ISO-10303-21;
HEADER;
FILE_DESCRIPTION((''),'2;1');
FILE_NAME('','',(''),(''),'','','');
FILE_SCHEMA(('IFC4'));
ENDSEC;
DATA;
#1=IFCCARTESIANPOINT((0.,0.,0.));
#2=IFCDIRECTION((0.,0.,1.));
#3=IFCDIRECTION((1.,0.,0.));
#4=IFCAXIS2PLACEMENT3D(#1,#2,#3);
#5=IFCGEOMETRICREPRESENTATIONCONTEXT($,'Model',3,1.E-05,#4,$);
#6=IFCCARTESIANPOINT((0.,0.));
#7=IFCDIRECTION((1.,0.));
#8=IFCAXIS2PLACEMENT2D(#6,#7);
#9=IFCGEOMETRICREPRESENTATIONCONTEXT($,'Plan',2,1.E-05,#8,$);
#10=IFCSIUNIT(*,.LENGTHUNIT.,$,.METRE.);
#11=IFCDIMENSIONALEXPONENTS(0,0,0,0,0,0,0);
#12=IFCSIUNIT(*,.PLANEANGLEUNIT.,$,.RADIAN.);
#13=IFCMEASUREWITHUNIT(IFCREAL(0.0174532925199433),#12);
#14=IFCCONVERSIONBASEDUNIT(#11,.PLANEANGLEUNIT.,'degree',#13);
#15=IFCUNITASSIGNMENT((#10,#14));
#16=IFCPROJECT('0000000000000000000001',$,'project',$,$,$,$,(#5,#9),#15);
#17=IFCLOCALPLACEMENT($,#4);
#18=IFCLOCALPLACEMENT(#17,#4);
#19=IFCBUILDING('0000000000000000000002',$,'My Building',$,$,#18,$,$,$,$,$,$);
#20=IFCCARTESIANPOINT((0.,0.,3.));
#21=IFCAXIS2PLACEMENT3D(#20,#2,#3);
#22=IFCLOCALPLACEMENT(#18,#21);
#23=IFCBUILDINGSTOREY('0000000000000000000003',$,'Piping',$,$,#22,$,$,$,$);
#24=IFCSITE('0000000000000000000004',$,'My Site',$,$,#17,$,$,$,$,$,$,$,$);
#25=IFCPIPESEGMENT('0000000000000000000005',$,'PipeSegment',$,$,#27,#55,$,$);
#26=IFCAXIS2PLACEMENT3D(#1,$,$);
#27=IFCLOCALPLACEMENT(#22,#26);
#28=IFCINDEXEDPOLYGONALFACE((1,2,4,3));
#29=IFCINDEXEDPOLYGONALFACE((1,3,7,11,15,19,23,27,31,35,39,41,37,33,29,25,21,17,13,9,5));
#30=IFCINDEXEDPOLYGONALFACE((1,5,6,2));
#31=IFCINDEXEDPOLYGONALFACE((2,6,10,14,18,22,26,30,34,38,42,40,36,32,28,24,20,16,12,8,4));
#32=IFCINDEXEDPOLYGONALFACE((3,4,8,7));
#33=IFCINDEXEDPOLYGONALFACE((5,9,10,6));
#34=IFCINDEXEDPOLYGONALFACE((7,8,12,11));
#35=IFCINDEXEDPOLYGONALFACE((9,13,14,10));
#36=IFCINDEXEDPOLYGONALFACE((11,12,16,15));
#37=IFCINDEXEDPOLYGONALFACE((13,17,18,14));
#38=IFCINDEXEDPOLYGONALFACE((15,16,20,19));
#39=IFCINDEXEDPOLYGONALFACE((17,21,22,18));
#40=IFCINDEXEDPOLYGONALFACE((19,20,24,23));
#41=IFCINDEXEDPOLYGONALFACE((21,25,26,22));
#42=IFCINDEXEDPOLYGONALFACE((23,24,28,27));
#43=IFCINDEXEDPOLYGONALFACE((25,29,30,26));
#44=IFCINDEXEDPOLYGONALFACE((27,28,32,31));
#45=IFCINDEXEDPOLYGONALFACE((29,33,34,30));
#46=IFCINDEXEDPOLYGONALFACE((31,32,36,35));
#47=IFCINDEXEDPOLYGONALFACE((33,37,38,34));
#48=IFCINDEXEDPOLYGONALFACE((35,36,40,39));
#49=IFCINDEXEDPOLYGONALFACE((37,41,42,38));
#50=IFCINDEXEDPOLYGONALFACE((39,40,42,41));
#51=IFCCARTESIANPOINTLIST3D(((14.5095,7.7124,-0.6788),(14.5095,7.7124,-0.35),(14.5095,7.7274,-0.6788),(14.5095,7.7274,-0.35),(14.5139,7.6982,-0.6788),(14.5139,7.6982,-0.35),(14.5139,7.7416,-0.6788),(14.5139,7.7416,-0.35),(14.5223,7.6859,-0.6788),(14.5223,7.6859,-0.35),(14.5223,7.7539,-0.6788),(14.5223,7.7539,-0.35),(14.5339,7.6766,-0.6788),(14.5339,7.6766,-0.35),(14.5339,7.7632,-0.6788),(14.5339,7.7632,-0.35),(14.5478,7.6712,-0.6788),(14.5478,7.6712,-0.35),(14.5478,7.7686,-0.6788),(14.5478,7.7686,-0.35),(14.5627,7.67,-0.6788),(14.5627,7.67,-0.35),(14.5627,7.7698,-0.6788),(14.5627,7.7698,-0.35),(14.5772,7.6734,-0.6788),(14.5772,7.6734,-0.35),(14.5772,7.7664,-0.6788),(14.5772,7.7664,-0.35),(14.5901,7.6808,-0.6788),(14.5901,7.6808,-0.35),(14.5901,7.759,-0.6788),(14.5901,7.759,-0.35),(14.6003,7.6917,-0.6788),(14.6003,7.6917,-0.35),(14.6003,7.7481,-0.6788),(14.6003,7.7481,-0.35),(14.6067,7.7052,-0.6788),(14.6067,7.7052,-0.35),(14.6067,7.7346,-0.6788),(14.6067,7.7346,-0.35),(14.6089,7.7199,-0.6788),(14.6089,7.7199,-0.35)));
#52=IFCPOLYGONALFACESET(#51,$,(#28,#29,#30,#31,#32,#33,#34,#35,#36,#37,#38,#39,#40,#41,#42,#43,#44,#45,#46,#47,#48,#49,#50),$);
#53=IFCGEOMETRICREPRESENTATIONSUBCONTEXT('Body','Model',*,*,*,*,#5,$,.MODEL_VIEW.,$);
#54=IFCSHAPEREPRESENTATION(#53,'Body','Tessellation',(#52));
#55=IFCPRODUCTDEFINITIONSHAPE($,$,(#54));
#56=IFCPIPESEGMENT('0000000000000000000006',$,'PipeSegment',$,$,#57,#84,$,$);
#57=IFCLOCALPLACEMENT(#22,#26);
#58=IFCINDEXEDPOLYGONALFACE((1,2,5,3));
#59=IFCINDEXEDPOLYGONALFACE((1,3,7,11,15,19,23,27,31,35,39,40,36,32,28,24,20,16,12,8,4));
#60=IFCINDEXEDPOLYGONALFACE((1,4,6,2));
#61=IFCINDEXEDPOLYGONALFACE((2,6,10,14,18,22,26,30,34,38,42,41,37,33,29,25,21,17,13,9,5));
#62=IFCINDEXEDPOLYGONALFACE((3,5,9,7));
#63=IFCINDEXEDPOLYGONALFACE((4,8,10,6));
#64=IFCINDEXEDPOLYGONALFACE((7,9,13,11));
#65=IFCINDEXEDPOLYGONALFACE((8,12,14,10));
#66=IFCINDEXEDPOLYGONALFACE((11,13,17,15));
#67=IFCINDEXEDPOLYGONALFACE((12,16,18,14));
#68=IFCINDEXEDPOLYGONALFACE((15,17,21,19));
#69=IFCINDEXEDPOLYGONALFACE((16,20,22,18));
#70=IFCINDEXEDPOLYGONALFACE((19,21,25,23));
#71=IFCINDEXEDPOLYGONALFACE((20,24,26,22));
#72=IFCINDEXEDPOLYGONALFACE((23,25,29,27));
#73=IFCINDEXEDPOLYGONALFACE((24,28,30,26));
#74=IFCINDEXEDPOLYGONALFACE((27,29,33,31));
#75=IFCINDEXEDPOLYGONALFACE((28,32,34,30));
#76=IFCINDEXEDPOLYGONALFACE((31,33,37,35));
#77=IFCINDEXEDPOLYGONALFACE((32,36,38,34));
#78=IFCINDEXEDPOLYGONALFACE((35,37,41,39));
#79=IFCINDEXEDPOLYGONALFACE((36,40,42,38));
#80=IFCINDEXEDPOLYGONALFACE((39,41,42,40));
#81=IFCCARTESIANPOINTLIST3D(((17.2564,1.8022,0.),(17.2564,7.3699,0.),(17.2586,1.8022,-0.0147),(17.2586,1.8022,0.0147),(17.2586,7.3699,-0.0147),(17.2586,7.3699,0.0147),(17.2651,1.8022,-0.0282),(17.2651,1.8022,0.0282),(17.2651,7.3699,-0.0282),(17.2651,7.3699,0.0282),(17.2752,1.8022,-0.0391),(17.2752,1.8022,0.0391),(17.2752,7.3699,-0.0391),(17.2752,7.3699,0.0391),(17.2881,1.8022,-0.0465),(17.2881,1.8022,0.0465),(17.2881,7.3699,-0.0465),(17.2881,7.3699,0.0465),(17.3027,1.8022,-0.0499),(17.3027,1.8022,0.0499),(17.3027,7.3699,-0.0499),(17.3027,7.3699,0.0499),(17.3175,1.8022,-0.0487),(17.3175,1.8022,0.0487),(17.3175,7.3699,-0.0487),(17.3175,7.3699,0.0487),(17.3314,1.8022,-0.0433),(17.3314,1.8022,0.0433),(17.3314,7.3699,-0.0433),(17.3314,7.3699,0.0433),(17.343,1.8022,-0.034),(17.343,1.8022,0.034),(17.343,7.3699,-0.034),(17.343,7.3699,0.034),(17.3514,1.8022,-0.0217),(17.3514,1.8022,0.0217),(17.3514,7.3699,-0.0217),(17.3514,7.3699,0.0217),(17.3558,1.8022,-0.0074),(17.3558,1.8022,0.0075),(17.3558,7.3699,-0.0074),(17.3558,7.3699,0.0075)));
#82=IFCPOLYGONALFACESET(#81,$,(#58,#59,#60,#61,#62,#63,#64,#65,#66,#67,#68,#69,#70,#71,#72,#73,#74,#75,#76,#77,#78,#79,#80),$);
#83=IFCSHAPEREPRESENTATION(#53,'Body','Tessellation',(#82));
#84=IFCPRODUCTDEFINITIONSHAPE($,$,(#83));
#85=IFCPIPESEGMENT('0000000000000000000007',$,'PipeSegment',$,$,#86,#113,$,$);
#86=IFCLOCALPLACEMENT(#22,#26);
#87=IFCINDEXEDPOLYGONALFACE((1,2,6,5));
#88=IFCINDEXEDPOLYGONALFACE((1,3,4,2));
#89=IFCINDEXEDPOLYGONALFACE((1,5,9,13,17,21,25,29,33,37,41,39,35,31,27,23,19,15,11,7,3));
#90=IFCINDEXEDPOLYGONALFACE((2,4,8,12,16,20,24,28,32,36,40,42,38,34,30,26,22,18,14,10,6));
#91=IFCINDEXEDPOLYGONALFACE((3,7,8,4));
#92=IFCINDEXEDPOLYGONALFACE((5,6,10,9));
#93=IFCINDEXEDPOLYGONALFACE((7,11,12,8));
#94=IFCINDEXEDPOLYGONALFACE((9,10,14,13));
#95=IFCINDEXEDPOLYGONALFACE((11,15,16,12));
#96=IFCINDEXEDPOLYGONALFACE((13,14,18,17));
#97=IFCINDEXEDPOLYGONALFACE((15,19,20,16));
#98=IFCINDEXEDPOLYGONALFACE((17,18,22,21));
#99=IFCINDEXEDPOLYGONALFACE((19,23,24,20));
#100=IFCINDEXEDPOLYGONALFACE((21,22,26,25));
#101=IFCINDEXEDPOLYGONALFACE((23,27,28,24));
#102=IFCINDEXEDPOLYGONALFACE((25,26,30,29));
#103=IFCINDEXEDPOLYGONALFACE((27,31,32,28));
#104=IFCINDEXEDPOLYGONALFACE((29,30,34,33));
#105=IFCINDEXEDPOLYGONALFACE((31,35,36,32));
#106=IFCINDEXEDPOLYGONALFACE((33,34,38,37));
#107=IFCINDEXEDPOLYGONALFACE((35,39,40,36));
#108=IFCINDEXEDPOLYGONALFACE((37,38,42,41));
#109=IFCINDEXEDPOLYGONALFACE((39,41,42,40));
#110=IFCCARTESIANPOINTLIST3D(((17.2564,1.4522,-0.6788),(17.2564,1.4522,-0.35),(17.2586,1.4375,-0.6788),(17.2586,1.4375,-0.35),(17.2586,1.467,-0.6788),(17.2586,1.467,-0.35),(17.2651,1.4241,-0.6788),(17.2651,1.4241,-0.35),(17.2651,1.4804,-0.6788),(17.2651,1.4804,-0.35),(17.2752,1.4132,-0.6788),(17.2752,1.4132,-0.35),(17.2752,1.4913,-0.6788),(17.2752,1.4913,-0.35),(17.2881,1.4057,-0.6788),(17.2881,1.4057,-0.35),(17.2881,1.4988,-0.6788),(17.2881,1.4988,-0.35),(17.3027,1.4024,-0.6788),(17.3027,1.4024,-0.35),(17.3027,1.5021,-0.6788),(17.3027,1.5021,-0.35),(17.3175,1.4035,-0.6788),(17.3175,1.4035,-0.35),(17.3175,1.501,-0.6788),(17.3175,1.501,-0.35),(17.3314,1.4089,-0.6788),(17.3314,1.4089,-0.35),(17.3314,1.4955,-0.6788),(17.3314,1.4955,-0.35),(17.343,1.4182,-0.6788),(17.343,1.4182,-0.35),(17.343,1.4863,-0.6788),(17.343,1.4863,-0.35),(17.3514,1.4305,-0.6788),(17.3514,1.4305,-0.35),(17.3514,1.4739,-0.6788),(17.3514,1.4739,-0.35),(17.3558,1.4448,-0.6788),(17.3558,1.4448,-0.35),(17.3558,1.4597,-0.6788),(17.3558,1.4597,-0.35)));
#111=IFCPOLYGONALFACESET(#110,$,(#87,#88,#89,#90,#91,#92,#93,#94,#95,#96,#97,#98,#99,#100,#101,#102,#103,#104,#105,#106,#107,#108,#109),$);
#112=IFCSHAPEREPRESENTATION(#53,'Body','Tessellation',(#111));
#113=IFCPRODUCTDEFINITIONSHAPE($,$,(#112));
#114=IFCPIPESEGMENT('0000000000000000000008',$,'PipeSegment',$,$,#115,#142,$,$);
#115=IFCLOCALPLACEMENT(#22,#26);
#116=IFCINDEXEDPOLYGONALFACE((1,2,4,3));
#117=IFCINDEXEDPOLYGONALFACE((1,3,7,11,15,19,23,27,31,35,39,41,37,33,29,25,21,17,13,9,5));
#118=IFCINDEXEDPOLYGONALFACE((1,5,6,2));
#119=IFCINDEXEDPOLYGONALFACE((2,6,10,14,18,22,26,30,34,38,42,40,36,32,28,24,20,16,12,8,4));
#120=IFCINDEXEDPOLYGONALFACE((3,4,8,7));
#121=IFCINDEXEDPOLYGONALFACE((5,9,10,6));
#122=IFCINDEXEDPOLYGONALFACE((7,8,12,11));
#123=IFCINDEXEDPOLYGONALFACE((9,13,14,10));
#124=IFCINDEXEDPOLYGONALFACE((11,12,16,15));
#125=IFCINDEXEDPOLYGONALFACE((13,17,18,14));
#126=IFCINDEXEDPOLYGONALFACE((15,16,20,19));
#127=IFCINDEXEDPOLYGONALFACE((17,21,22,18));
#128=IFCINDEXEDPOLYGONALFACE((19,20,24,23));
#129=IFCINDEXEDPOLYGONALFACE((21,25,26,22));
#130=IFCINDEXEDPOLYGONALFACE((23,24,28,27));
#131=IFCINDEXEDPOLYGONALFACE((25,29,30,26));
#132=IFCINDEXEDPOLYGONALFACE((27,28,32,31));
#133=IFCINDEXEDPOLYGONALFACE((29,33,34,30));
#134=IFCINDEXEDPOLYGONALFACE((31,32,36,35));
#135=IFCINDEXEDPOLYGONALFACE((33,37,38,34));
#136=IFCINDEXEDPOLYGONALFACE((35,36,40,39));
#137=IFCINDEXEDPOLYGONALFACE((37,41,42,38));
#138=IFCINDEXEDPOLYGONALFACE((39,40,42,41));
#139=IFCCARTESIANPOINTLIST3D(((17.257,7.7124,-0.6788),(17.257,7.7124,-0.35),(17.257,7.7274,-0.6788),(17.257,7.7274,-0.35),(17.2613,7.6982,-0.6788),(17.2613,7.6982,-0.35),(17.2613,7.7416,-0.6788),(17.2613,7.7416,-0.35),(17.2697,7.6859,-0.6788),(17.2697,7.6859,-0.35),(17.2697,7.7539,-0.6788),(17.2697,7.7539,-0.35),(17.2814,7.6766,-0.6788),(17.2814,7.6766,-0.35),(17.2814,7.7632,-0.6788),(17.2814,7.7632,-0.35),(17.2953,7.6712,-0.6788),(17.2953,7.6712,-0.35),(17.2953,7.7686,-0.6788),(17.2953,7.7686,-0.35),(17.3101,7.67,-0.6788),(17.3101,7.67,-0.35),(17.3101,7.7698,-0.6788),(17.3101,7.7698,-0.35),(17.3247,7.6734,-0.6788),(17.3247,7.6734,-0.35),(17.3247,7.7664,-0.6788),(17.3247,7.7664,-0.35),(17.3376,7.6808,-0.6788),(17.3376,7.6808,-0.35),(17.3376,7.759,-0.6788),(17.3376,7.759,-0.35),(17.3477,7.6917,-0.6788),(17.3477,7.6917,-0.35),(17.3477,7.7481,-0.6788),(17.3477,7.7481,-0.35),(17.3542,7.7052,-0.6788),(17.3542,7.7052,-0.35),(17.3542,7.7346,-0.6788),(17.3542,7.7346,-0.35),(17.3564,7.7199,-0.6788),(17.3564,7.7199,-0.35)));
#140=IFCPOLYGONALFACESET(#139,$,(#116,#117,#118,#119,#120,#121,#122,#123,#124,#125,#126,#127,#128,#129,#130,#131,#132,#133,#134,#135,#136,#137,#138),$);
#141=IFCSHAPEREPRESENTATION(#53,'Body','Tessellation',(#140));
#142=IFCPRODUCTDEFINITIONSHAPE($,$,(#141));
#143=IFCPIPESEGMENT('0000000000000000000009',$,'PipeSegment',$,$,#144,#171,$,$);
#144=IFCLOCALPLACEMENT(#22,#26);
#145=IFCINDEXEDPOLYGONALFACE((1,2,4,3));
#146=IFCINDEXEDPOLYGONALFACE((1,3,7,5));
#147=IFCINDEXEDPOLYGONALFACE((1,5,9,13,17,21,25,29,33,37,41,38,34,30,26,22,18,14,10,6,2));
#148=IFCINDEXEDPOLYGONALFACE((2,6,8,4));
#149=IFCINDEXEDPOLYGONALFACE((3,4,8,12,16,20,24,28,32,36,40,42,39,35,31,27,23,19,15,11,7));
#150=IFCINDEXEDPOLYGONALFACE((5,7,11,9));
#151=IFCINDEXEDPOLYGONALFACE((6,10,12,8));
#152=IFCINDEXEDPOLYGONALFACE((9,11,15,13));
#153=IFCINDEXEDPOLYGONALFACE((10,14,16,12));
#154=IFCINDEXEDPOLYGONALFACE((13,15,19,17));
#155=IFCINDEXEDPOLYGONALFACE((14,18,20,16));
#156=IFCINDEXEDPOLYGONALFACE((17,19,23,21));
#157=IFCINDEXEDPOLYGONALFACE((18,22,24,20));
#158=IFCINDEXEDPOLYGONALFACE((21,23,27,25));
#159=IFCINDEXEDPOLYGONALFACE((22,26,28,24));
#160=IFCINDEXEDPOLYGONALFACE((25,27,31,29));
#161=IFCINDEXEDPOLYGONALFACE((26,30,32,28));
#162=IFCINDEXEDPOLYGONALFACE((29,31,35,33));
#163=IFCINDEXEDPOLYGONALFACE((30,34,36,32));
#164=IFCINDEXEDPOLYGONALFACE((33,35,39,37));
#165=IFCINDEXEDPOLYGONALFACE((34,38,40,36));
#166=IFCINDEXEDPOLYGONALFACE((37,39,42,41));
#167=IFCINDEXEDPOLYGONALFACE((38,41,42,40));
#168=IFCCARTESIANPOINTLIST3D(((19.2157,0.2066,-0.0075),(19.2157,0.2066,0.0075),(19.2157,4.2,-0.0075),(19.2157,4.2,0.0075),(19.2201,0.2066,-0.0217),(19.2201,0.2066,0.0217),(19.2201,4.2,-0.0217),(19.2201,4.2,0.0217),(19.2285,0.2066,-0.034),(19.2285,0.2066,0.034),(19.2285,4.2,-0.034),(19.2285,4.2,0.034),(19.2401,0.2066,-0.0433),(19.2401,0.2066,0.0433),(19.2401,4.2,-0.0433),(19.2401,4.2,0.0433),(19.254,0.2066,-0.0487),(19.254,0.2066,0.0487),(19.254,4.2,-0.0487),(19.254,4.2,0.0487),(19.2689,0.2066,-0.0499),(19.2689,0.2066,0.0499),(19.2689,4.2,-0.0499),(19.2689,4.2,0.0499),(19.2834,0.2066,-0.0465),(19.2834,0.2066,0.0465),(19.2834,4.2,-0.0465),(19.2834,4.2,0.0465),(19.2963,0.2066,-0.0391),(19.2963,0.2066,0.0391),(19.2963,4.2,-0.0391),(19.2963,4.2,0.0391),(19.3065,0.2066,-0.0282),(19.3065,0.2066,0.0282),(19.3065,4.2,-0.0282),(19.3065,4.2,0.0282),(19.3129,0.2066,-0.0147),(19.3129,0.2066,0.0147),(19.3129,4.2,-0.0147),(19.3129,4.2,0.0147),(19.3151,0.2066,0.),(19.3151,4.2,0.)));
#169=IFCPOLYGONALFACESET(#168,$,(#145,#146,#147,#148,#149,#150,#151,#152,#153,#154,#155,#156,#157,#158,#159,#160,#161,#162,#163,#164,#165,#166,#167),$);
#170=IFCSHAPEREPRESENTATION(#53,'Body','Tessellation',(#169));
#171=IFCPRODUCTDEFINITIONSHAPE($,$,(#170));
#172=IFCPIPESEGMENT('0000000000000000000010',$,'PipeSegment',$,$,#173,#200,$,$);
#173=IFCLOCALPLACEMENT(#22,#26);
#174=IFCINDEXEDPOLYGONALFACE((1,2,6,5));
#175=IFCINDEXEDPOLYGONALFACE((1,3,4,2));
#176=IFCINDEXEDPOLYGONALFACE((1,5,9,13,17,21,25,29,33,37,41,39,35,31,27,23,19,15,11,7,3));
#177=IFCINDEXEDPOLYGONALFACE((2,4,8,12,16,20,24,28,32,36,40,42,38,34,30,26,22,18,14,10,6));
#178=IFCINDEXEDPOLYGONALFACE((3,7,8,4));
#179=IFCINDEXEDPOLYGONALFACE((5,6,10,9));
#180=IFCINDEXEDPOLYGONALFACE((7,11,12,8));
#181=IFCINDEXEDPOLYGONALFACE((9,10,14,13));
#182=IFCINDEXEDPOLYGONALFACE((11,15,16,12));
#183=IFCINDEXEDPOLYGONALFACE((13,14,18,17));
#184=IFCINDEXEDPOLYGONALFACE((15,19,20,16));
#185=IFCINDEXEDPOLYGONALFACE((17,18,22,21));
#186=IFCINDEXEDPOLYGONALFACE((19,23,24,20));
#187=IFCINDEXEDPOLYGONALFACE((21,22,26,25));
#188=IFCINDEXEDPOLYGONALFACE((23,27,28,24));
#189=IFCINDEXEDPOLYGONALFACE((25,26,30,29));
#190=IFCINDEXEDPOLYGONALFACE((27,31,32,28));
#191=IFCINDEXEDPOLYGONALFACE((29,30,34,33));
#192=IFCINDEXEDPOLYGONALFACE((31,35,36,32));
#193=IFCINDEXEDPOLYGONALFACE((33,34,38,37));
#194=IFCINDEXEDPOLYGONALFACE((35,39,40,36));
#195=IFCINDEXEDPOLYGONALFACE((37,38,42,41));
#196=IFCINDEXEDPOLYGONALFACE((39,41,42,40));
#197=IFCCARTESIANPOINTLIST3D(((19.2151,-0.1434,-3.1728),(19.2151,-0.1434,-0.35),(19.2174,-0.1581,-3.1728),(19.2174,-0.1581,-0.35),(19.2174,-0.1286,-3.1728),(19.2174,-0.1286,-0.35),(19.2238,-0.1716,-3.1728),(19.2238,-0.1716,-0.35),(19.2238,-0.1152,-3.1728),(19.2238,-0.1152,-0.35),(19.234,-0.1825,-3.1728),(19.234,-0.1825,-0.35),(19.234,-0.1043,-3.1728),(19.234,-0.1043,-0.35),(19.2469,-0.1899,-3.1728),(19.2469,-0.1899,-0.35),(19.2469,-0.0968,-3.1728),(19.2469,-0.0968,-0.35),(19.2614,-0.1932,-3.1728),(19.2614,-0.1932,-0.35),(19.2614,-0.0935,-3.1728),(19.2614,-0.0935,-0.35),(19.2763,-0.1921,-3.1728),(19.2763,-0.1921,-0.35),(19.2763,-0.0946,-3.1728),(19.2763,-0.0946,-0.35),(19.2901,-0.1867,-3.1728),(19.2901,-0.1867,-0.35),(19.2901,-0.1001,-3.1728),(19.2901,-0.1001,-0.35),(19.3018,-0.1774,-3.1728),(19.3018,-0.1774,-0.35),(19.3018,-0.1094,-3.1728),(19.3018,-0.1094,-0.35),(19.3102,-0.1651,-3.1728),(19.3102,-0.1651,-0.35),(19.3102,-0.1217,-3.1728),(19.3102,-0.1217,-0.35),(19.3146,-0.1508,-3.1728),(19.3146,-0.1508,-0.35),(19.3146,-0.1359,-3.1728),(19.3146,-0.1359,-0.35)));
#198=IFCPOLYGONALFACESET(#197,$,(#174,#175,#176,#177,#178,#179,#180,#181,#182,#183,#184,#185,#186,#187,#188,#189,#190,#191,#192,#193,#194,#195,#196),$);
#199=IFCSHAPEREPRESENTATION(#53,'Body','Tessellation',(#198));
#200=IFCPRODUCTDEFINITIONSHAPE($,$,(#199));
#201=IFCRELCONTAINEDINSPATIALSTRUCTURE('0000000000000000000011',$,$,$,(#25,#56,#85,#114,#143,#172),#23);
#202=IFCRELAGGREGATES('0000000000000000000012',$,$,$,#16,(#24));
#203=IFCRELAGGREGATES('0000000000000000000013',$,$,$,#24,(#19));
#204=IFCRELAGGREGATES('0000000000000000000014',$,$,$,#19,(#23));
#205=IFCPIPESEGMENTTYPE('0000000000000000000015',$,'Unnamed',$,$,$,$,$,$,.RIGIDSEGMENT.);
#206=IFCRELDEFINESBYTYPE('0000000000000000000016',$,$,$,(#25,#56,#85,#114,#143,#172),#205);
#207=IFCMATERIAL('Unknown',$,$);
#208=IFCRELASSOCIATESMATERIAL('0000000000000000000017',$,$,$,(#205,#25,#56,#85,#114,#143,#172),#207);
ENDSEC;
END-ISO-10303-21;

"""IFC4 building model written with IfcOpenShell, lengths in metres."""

from ifc_helpers import new_model, entity, si_unit, converted_unit, frame, origin_with_axes, origin_2d_with_axis, place, context, subcontext, project, spatial, circle, extrude, material, material_profile, profile_set, profile_usage, type_object, element, save


model = new_model("IFC4")

# Units and contexts
model_context = context("Model", 3, precision=1e-05, world=origin_with_axes())
plan_context = context("Plan", 2, precision=1e-05, world=origin_2d_with_axis())
body_context = subcontext(model_context, "Body", "Model", "MODEL_VIEW")
ifc_project = project(units=[si_unit("LENGTHUNIT", "METRE"), converted_unit("PLANEANGLEUNIT", "degree", entity("IfcReal", 0.0174532925199433), si_unit("PLANEANGLEUNIT", "RADIAN"), dimensions=[0, 0, 0, 0, 0, 0, 0])], contexts=[model_context, plan_context])

# Site, building, storey
site_placement = place(None, origin_with_axes())
site = spatial("IfcSite", under=ifc_project, at=site_placement, Name="My Site")
building_placement = place(site_placement, origin_with_axes())
building = spatial("IfcBuilding", under=site, at=building_placement, Name="My Building")
storey_placement = place(building_placement, frame((0.0, 0.0, 3.0), z_axis=(0.0, 0.0, 1.0), x_axis=(1.0, 0.0, 0.0)))
storey = spatial("IfcBuildingStorey", under=building, at=storey_placement, Name="Piping")

# Pipe segments
ifc_material = material(Name="Unknown")
ifc_material_profile = material_profile(ifc_material, circle(Radius=0.05))
ifc_profile_set = profile_set([ifc_material_profile])
pipe_segment_type = type_object("IfcPipeSegmentType", Name="Unnamed", PredefinedType="RIGIDSEGMENT", material=ifc_profile_set)
ifc_profile_usage_1 = profile_usage(ifc_profile_set, cardinal=5)
pipe_segment_1_placement = place(storey_placement, frame((14.5589, 7.7199, -0.6788), z_axis=(0.0, 0.0, 1.0), x_axis=(1.0, 0.0, 0.0)))
element("IfcPipeSegment", 1, at=pipe_segment_1_placement, inside=storey, type_object=pipe_segment_type, material=ifc_profile_usage_1, Name="PipeSegment", context=body_context, shape_type="SweptSolid", body=[
    extrude(circle(Radius=0.05), origin_with_axes(), (0.0, 0.0, 1.0), 0.3288),
])
ifc_profile_usage_2 = profile_usage(ifc_profile_set, cardinal=5)
pipe_segment_2_placement = place(storey_placement, frame((17.3064, 1.8022, 0.0), z_axis=(0.0, 1.0, 0.0), x_axis=(-1.0, 0.0, 0.0)))
element("IfcPipeSegment", 2, at=pipe_segment_2_placement, inside=storey, type_object=pipe_segment_type, material=ifc_profile_usage_2, Name="PipeSegment", context=body_context, shape_type="SweptSolid", body=[
    extrude(circle(Radius=0.05), origin_with_axes(), (0.0, 0.0, 1.0), 5.5677),
])
ifc_profile_usage_3 = profile_usage(ifc_profile_set, cardinal=5)
pipe_segment_3_placement = place(storey_placement, frame((17.3064, 1.4522, -0.35), z_axis=(0.0, 0.0, -1.0), x_axis=(-1.0, 0.0, 0.0)))
element("IfcPipeSegment", 3, at=pipe_segment_3_placement, inside=storey, type_object=pipe_segment_type, material=ifc_profile_usage_3, Name="PipeSegment", context=body_context, shape_type="SweptSolid", body=[
    extrude(circle(Radius=0.05), origin_with_axes(), (0.0, 0.0, 1.0), 0.3288),
])
ifc_profile_usage_4 = profile_usage(ifc_profile_set, cardinal=5)
pipe_segment_4_placement = place(storey_placement, frame((17.3064, 7.7199, -0.6788), z_axis=(0.0, 0.0, 1.0), x_axis=(1.0, 0.0, 0.0)))
element("IfcPipeSegment", 4, at=pipe_segment_4_placement, inside=storey, type_object=pipe_segment_type, material=ifc_profile_usage_4, Name="PipeSegment", context=body_context, shape_type="SweptSolid", body=[
    extrude(circle(Radius=0.05), origin_with_axes(), (0.0, 0.0, 1.0), 0.3288),
])
ifc_profile_usage_5 = profile_usage(ifc_profile_set, cardinal=5)
pipe_segment_5_placement = place(storey_placement, frame((19.2651, 4.2, 0.0), z_axis=(0.0, -1.0, 0.0), x_axis=(1.0, 0.0, 0.0)))
element("IfcPipeSegment", 5, at=pipe_segment_5_placement, inside=storey, type_object=pipe_segment_type, material=ifc_profile_usage_5, Name="PipeSegment", context=body_context, shape_type="SweptSolid", body=[
    extrude(circle(Radius=0.05), origin_with_axes(), (0.0, 0.0, 1.0), 3.9934),
])
ifc_profile_usage_6 = profile_usage(ifc_profile_set, cardinal=5)
pipe_segment_6_placement = place(storey_placement, frame((19.2651, -0.1434, -0.35), z_axis=(0.0, 0.0, -1.0), x_axis=(-1.0, 0.0, 0.0)))
element("IfcPipeSegment", 6, at=pipe_segment_6_placement, inside=storey, type_object=pipe_segment_type, material=ifc_profile_usage_6, Name="PipeSegment", context=body_context, shape_type="SweptSolid", body=[
    extrude(circle(Radius=0.05), origin_with_axes(), (0.0, 0.0, 1.0), 2.8228),
])

save(model, "model.ifc")
